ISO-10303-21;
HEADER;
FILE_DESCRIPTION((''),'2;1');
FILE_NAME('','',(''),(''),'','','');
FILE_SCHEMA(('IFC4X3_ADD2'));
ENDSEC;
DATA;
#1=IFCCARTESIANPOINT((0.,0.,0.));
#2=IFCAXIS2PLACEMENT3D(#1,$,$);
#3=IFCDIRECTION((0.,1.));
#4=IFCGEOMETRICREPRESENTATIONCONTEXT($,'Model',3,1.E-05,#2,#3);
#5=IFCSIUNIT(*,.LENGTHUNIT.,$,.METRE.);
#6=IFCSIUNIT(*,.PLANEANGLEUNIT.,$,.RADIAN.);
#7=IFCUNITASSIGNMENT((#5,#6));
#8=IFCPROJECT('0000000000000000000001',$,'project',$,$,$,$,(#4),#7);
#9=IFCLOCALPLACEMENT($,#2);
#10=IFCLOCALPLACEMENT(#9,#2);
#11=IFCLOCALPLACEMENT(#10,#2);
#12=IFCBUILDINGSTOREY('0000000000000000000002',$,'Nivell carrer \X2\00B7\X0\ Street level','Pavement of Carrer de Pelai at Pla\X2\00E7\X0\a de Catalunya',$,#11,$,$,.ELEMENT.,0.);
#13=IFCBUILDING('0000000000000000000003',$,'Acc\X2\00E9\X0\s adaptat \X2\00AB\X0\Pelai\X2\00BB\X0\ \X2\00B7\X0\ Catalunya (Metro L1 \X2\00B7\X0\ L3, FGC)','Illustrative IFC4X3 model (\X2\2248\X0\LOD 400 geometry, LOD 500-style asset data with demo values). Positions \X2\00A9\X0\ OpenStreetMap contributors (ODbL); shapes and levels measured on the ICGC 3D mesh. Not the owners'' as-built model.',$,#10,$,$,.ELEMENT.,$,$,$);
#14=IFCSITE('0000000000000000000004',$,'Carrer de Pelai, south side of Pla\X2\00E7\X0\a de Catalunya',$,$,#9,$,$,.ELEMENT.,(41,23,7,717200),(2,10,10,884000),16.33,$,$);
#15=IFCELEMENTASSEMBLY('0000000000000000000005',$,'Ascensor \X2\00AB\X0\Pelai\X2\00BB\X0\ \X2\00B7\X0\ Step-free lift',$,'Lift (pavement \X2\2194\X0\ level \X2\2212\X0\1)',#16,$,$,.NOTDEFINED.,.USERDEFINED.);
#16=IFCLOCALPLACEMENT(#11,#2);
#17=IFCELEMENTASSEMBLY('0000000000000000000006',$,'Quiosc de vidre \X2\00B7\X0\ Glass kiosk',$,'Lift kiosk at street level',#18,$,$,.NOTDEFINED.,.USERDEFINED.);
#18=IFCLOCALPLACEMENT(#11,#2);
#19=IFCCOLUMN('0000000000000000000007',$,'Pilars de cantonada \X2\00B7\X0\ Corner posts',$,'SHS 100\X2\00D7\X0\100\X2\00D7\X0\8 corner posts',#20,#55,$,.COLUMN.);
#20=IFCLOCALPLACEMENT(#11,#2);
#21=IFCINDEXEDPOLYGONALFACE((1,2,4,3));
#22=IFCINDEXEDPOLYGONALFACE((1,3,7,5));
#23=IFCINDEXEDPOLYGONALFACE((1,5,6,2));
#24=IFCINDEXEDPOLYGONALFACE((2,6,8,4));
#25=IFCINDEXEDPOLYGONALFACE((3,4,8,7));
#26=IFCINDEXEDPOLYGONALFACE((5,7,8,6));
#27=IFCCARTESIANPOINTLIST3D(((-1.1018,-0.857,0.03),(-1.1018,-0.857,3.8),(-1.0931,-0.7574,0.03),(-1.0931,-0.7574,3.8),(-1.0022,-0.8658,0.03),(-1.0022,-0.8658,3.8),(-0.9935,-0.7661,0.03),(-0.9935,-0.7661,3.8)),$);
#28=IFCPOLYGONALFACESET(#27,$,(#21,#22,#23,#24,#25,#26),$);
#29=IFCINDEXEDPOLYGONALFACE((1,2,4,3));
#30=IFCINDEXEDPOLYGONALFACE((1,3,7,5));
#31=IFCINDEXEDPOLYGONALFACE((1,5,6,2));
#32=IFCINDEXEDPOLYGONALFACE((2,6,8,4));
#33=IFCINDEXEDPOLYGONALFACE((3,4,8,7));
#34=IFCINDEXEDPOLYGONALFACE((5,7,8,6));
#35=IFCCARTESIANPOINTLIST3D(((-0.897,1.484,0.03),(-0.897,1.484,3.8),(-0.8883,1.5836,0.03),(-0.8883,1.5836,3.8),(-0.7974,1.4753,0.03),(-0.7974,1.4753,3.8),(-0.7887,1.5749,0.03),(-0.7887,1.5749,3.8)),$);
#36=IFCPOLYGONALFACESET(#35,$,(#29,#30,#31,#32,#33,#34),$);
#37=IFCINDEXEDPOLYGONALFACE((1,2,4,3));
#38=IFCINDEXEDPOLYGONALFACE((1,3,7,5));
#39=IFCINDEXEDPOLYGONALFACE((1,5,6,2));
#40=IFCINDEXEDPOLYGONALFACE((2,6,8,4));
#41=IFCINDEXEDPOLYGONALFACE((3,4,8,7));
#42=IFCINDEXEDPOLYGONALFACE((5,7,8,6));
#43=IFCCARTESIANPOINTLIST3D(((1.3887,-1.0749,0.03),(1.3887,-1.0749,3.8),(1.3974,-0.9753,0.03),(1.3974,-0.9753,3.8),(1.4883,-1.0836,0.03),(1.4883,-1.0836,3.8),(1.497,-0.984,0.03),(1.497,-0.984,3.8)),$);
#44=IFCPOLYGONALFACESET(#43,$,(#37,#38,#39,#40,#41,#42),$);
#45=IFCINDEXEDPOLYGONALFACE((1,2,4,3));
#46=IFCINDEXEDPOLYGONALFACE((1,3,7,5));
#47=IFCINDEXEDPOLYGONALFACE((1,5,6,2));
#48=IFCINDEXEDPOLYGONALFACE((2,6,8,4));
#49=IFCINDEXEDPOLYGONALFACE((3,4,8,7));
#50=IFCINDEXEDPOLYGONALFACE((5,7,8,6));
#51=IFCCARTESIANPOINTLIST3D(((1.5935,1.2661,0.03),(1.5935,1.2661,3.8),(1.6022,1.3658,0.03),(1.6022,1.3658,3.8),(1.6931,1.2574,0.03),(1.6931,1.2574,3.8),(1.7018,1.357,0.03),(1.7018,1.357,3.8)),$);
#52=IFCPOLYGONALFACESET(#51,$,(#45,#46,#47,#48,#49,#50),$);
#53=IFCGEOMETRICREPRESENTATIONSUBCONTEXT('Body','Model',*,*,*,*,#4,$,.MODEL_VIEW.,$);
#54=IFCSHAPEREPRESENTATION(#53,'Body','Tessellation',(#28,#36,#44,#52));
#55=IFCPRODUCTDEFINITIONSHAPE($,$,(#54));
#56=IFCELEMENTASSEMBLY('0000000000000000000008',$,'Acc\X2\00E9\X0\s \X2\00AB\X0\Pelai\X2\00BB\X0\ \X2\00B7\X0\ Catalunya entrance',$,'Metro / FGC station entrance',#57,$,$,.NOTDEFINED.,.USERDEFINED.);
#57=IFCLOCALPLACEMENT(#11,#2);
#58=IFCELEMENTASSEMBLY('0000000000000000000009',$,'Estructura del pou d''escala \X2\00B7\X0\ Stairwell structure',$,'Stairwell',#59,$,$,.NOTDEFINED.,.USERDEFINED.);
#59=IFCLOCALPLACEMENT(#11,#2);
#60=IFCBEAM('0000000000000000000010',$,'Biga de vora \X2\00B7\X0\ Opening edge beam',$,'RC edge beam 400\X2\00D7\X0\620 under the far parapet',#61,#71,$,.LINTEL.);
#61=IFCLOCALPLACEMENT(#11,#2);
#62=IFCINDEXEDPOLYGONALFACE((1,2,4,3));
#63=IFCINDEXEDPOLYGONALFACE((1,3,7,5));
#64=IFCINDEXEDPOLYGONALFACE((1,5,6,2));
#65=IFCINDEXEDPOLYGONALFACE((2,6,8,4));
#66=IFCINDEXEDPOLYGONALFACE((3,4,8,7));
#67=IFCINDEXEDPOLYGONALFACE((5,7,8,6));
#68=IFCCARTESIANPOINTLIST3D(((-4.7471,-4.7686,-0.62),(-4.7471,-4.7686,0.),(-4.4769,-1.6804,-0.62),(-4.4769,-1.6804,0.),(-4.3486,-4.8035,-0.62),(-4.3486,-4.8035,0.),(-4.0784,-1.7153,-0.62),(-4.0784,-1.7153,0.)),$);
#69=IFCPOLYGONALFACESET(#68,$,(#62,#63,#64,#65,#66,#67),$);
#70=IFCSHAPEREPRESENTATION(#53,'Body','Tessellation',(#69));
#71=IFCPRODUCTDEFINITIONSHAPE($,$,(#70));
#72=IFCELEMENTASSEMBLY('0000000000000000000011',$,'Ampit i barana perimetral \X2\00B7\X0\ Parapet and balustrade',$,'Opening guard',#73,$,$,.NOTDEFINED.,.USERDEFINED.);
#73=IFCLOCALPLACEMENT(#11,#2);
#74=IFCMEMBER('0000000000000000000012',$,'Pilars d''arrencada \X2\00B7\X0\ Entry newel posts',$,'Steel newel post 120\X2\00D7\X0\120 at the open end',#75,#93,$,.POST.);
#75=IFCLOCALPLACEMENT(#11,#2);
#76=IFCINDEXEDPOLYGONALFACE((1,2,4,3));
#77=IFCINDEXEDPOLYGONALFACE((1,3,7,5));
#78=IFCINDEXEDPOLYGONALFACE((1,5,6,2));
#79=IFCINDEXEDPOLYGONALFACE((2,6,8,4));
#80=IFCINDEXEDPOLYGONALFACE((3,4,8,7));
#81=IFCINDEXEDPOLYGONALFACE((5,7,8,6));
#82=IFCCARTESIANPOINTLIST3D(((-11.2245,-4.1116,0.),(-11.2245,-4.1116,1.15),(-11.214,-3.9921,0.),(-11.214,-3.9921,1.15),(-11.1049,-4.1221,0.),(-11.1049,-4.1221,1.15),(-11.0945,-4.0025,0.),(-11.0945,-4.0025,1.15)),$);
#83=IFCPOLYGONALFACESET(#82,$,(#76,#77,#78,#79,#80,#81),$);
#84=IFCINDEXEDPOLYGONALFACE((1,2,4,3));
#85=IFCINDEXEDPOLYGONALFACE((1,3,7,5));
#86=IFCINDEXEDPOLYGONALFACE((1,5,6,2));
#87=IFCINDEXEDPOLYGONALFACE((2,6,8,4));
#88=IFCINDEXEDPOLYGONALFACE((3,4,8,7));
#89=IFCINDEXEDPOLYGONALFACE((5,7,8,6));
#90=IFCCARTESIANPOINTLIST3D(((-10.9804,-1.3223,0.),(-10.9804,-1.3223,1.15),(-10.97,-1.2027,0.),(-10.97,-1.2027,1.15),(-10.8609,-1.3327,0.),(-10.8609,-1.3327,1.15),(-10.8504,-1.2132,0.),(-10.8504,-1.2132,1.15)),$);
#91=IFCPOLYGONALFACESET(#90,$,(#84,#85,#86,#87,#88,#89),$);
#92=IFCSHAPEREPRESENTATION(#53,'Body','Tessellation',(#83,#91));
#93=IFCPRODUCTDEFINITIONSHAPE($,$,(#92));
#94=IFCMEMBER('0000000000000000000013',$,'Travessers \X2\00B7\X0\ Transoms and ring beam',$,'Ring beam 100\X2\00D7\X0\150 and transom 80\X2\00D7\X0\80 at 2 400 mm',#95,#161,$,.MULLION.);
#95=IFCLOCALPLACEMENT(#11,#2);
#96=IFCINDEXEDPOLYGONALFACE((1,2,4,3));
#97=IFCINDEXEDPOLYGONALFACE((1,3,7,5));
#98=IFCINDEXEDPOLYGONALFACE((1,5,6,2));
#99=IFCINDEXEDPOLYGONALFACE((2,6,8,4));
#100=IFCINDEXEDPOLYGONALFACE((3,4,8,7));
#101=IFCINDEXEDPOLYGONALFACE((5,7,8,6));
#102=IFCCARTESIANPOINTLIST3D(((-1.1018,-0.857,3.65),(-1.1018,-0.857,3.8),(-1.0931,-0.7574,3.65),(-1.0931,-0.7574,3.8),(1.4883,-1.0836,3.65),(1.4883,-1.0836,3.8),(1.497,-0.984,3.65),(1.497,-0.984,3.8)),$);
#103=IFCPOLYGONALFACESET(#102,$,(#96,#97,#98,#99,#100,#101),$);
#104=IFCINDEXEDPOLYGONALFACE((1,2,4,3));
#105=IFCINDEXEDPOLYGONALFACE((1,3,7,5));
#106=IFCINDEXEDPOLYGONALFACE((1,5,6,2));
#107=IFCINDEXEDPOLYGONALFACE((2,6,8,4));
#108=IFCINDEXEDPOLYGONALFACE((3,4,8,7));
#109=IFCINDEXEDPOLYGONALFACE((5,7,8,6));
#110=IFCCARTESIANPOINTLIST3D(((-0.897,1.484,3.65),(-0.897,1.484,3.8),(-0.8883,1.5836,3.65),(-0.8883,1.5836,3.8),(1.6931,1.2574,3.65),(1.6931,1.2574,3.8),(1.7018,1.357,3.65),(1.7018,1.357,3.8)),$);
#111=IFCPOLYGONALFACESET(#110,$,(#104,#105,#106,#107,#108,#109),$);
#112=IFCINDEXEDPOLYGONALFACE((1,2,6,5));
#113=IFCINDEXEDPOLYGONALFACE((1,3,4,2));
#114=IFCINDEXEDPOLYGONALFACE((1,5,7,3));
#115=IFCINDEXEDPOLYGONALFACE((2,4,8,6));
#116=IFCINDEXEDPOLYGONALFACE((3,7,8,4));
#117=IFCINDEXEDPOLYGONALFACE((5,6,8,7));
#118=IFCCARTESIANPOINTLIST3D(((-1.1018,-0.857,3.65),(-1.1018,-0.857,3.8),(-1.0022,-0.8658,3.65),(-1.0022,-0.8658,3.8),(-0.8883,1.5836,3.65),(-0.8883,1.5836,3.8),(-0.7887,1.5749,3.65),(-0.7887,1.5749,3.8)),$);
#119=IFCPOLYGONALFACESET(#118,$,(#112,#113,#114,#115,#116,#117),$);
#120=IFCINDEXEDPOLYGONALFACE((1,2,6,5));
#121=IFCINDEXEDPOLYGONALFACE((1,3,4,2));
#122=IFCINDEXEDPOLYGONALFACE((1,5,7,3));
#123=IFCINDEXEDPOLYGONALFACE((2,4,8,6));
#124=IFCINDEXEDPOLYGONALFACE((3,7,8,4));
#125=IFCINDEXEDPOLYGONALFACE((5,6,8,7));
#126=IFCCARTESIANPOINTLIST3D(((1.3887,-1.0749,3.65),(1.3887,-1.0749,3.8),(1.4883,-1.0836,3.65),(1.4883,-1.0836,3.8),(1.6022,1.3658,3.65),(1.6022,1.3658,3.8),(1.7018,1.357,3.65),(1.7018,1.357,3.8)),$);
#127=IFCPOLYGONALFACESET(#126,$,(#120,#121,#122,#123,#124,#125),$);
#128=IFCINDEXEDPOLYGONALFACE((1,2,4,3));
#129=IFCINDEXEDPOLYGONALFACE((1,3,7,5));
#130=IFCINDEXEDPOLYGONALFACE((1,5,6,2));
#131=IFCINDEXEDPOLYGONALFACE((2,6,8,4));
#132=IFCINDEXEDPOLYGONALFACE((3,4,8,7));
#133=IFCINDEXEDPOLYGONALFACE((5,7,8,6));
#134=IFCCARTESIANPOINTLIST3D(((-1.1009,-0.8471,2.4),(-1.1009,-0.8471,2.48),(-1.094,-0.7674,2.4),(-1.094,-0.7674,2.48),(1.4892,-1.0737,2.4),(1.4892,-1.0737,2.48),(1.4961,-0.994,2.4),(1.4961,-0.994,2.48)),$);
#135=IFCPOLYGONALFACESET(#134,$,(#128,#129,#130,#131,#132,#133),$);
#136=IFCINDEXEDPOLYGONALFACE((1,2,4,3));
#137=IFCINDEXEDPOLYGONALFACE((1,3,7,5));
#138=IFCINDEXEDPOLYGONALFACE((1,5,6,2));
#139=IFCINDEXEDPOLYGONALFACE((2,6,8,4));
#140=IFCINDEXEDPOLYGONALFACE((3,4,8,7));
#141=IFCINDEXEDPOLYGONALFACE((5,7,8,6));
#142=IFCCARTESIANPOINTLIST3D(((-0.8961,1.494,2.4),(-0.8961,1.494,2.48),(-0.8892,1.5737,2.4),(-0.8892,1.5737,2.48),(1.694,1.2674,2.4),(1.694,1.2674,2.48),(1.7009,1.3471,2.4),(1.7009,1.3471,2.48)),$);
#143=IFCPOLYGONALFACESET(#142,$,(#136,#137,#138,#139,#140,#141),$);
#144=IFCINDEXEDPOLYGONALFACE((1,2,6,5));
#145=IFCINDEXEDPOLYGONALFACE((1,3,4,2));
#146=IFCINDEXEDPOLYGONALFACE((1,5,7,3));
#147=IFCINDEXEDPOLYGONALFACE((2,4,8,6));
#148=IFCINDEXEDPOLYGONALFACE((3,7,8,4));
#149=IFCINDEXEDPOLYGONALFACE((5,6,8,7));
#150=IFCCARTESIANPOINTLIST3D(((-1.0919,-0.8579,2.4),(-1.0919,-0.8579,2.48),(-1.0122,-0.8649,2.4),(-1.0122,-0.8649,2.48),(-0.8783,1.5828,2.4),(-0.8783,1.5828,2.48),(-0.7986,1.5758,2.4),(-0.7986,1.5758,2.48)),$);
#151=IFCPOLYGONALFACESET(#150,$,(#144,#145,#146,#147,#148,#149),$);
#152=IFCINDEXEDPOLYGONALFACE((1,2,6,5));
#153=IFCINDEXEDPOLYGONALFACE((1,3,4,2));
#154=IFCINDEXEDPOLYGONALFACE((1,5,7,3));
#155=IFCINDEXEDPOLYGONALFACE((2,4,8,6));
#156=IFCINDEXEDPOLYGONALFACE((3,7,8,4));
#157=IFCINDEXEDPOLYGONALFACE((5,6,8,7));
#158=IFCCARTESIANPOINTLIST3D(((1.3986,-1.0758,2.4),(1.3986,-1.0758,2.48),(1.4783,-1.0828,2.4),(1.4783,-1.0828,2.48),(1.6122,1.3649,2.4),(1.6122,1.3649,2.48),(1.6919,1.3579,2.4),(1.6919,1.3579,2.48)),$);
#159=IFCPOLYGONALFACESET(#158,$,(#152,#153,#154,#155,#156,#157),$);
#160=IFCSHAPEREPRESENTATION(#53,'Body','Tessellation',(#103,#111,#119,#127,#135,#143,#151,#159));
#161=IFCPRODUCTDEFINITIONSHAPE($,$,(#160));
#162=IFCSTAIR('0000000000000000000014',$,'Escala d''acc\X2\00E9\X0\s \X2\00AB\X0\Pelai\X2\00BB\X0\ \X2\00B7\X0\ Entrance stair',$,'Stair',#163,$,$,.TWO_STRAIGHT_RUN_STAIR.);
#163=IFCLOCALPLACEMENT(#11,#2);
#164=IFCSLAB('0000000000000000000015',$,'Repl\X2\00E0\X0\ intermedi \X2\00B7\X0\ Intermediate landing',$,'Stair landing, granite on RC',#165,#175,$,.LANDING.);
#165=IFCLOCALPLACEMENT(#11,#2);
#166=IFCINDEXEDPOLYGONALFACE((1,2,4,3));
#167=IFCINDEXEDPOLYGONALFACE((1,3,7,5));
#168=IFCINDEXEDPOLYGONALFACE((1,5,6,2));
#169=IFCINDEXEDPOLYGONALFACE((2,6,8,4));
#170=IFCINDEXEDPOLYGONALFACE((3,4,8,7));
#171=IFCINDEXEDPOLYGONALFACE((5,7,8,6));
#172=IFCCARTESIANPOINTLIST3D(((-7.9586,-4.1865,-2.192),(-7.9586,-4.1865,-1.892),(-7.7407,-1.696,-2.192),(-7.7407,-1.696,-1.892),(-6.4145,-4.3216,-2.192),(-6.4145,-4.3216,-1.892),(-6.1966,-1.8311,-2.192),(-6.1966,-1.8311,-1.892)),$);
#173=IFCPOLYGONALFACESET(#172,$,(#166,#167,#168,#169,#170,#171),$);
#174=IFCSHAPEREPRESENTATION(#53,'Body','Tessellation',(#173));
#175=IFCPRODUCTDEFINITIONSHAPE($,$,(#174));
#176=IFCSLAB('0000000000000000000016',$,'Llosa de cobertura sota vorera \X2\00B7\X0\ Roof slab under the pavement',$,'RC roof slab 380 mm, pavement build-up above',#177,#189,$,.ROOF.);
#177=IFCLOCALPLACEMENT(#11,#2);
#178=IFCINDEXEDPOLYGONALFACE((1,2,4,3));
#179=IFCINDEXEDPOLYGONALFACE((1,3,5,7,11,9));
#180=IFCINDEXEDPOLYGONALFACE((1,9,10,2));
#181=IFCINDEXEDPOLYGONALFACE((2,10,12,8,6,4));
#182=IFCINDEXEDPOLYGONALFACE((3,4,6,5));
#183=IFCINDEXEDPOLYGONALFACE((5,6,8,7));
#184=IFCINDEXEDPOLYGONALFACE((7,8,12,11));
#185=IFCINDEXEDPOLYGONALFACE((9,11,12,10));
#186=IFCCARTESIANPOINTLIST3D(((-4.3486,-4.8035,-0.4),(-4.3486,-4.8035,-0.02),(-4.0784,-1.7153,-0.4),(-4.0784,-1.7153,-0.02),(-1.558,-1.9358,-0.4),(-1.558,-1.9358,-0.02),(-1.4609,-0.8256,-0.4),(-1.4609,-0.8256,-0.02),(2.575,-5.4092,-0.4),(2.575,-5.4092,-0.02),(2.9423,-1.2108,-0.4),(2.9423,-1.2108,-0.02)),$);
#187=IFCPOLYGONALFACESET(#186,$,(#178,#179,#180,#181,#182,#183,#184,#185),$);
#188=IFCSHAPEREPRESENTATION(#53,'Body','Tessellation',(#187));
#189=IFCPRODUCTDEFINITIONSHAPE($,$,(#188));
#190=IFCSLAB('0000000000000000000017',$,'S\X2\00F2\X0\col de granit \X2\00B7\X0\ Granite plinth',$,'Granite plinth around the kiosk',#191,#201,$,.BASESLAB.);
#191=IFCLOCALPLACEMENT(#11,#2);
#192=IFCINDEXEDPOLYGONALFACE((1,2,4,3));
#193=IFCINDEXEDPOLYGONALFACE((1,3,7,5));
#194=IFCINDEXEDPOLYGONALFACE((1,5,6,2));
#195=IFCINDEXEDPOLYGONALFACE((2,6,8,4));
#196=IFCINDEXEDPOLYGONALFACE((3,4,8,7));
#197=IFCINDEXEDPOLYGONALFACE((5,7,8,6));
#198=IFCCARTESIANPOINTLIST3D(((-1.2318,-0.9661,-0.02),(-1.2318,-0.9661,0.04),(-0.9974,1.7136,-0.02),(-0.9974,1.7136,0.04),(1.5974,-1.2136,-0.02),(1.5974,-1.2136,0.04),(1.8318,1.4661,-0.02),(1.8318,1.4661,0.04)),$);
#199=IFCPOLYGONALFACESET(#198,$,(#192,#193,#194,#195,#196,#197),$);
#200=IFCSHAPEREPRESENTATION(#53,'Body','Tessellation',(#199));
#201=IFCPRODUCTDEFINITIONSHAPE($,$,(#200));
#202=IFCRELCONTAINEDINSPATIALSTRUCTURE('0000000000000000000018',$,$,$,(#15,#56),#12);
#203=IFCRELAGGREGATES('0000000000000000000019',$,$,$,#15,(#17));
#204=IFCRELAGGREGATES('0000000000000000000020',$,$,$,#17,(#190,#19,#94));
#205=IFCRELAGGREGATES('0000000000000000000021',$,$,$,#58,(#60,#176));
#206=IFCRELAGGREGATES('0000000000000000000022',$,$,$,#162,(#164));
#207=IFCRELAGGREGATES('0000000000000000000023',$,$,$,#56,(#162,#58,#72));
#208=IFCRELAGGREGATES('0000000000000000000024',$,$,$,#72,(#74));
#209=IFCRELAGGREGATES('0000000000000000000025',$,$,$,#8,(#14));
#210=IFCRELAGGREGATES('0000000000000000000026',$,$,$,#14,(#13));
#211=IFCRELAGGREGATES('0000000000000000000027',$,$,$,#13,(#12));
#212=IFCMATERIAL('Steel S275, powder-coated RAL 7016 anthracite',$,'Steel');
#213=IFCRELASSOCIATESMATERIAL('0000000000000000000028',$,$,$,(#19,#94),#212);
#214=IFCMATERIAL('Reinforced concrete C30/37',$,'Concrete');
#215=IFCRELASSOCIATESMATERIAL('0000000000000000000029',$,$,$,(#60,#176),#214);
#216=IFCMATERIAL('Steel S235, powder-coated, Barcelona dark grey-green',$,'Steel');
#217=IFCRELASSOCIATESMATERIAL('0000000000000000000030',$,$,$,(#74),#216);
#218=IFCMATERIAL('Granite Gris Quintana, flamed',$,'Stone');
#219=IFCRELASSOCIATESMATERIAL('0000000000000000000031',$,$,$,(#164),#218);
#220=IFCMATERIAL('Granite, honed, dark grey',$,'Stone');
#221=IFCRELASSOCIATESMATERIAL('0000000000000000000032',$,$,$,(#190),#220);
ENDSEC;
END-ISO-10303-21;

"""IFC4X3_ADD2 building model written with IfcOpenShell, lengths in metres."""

from ifc_helpers import new_model, si_unit, direction, frame, frame_2d, origin, place, context, subcontext, project, spatial, polyline, rectangle, outline, extrude, material, element, aggregate, save


model = new_model("IFC4X3_ADD2")

# Units and contexts
model_context = context("Model", 3, precision=1e-05, world=origin(), true_north=direction((0.0, 1.0)))
body_context = subcontext(model_context, "Body", "Model", "MODEL_VIEW")
ifc_project = project(units=[si_unit("LENGTHUNIT", "METRE"), si_unit("PLANEANGLEUNIT", "RADIAN")], contexts=[model_context])

# Site, building, storey
site_placement = place(None, origin())
site = spatial("IfcSite", under=ifc_project, at=site_placement, Name="Carrer de Pelai, south side of Plaça de Catalunya", CompositionType="ELEMENT", RefLatitude=(41, 23, 7, 717200), RefLongitude=(2, 10, 10, 884000), RefElevation=16.33)
building_placement = place(site_placement, origin())
building = spatial("IfcBuilding", under=site, at=building_placement, Name="Accés adaptat «Pelai» · Catalunya (Metro L1 · L3, FGC)", Description="Illustrative IFC4X3 model (≈LOD 400 geometry, LOD 500-style asset data with demo values). Positions © OpenStreetMap contributors (ODbL); shapes and levels measured on the ICGC 3D mesh. Not the owners' as-built model.", CompositionType="ELEMENT")
storey_placement = place(building_placement, origin())
storey = spatial("IfcBuildingStorey", under=building, at=storey_placement, Name="Nivell carrer · Street level", Description="Pavement of Carrer de Pelai at Plaça de Catalunya", CompositionType="ELEMENT", Elevation=0.0)

# Element assemblies, column
assembly_1_placement = place(building_placement, origin())
assembly_1 = element("IfcElementAssembly", 1, at=assembly_1_placement, inside=storey, Name="Ascensor «Pelai» · Step-free lift", ObjectType="Lift (pavement ↔ level −1)", AssemblyPlace="NOTDEFINED", PredefinedType="USERDEFINED")
assembly_2_placement = place(building_placement, origin())
assembly_2 = element("IfcElementAssembly", 2, at=assembly_2_placement, Name="Quiosc de vidre · Glass kiosk", ObjectType="Lift kiosk at street level", AssemblyPlace="NOTDEFINED", PredefinedType="USERDEFINED")
aggregate(assembly_1, [assembly_2])
ifc_material_1 = material(Name="Steel S275, powder-coated RAL 7016 anthracite", Category="Steel")
column_placement = place(building_placement, origin())
column = element("IfcColumn", 3, at=column_placement, material=ifc_material_1, Name="Pilars de cantonada · Corner posts", ObjectType="SHS 100×100×8 corner posts", PredefinedType="COLUMN", context=body_context, shape_type="SweptSolid", body=[
    extrude(rectangle(XDim=0.1, YDim=0.1, at=frame_2d((0.0, 0.0), x_axis=(0.996195, -0.087156))), frame((-1.0477, -0.8116, 0.03)), (0.0, 0.0, 1.0), 3.77),
    extrude(rectangle(XDim=0.1, YDim=0.1, at=frame_2d((0.0, 0.0), x_axis=(0.996195, -0.087156))), frame((-0.8428, 1.5295, 0.03)), (0.0, 0.0, 1.0), 3.77),
    extrude(rectangle(XDim=0.1, YDim=0.1, at=frame_2d((0.0, 0.0), x_axis=(0.996195, -0.087156))), frame((1.4428, -1.0295, 0.03)), (0.0, 0.0, 1.0), 3.77),
    extrude(rectangle(XDim=0.1, YDim=0.1, at=frame_2d((0.0, 0.0), x_axis=(0.996195, -0.087156))), frame((1.6477, 1.3116, 0.03)), (0.0, 0.0, 1.0), 3.77),
])

# Element assemblies, beam, member
assembly_3_placement = place(building_placement, origin())
assembly_3 = element("IfcElementAssembly", 4, at=assembly_3_placement, inside=storey, Name="Accés «Pelai» · Catalunya entrance", ObjectType="Metro / FGC station entrance", AssemblyPlace="NOTDEFINED", PredefinedType="USERDEFINED")
assembly_4_placement = place(building_placement, origin())
assembly_4 = element("IfcElementAssembly", 5, at=assembly_4_placement, Name="Estructura del pou d'escala · Stairwell structure", ObjectType="Stairwell", AssemblyPlace="NOTDEFINED", PredefinedType="USERDEFINED")
ifc_material_2 = material(Name="Reinforced concrete C30/37", Category="Concrete")
beam_placement = place(building_placement, origin())
beam = element("IfcBeam", 6, at=beam_placement, material=ifc_material_2, Name="Biga de vora · Opening edge beam", ObjectType="RC edge beam 400×620 under the far parapet", PredefinedType="LINTEL", context=body_context, shape_type="SweptSolid", body=[
    extrude(rectangle(XDim=0.4, YDim=3.1, at=frame_2d((0.0, 0.0), x_axis=(0.996195, -0.087156))), frame((-4.4127, -3.242, -0.62)), (0.0, 0.0, 1.0), 0.62),
])
assembly_5_placement = place(building_placement, origin())
assembly_5 = element("IfcElementAssembly", 7, at=assembly_5_placement, Name="Ampit i barana perimetral · Parapet and balustrade", ObjectType="Opening guard", AssemblyPlace="NOTDEFINED", PredefinedType="USERDEFINED")
ifc_material_3 = material(Name="Steel S235, powder-coated, Barcelona dark grey-green", Category="Steel")
member_1_placement = place(building_placement, origin())
member_1 = element("IfcMember", 8, at=member_1_placement, material=ifc_material_3, Name="Pilars d'arrencada · Entry newel posts", ObjectType="Steel newel post 120×120 at the open end", PredefinedType="POST", context=body_context, shape_type="SweptSolid", body=[
    extrude(rectangle(XDim=0.12, YDim=0.12, at=frame_2d((0.0, 0.0), x_axis=(0.996195, -0.087156))), frame((-11.1595, -4.0571, 0.0)), (0.0, 0.0, 1.0), 1.15),
    extrude(rectangle(XDim=0.12, YDim=0.12, at=frame_2d((0.0, 0.0), x_axis=(0.996195, -0.087156))), frame((-10.9154, -1.2677, 0.0)), (0.0, 0.0, 1.0), 1.15),
])

# Member
member_2_placement = place(building_placement, origin())
member_2 = element("IfcMember", 9, at=member_2_placement, material=ifc_material_1, Name="Travessers · Transoms and ring beam", ObjectType="Ring beam 100×150 and transom 80×80 at 2 400 mm", PredefinedType="MULLION", context=body_context, shape_type="SweptSolid", body=[
    extrude(rectangle(XDim=2.6, YDim=0.1, at=frame_2d((0.0, 0.0), x_axis=(0.996195, -0.087156))), frame((0.1976, -0.9205, 3.65)), (0.0, 0.0, 1.0), 0.15),
    extrude(rectangle(XDim=2.6, YDim=0.1, at=frame_2d((0.0, 0.0), x_axis=(0.996195, -0.087156))), frame((0.4024, 1.4205, 3.65)), (0.0, 0.0, 1.0), 0.15),
    extrude(rectangle(XDim=0.1, YDim=2.45, at=frame_2d((0.0, 0.0), x_axis=(0.996195, -0.087156))), frame((-0.9452, 0.3589, 3.65)), (0.0, 0.0, 1.0), 0.15),
    extrude(rectangle(XDim=0.1, YDim=2.45, at=frame_2d((0.0, 0.0), x_axis=(0.996195, -0.087156))), frame((1.5452, 0.1411, 3.65)), (0.0, 0.0, 1.0), 0.15),
    extrude(rectangle(XDim=2.6, YDim=0.08, at=frame_2d((0.0, 0.0), x_axis=(0.996195, -0.087156))), frame((0.1976, -0.9205, 2.4)), (0.0, 0.0, 1.0), 0.08),
    extrude(rectangle(XDim=2.6, YDim=0.08, at=frame_2d((0.0, 0.0), x_axis=(0.996195, -0.087156))), frame((0.4024, 1.4205, 2.4)), (0.0, 0.0, 1.0), 0.08),
    extrude(rectangle(XDim=0.08, YDim=2.45, at=frame_2d((0.0, 0.0), x_axis=(0.996195, -0.087156))), frame((-0.9452, 0.3589, 2.4)), (0.0, 0.0, 1.0), 0.08),
    extrude(rectangle(XDim=0.08, YDim=2.45, at=frame_2d((0.0, 0.0), x_axis=(0.996195, -0.087156))), frame((1.5452, 0.1411, 2.4)), (0.0, 0.0, 1.0), 0.08),
])

# Stair, slab
stair_placement = place(building_placement, origin())
stair = element("IfcStair", 10, at=stair_placement, Name="Escala d'accés «Pelai» · Entrance stair", ObjectType="Stair", PredefinedType="TWO_STRAIGHT_RUN_STAIR")
ifc_material_4 = material(Name="Granite Gris Quintana, flamed", Category="Stone")
slab_1_placement = place(building_placement, origin())
slab_1 = element("IfcSlab", 11, at=slab_1_placement, material=ifc_material_4, Name="Replà intermedi · Intermediate landing", ObjectType="Stair landing, granite on RC", PredefinedType="LANDING", context=body_context, shape_type="SweptSolid", body=[
    extrude(rectangle(XDim=1.55, YDim=2.5, at=frame_2d((0.0, 0.0), x_axis=(0.996195, -0.087156))), frame((-7.0776, -3.0088, -2.192)), (0.0, 0.0, 1.0), 0.3),
])

# Slabs
slab_2_placement = place(building_placement, origin())
slab_2 = element("IfcSlab", 12, at=slab_2_placement, material=ifc_material_2, Name="Llosa de cobertura sota vorera · Roof slab under the pavement", ObjectType="RC roof slab 380 mm, pavement build-up above", PredefinedType="ROOF", context=body_context, shape_type="SweptSolid", body=[
    extrude(outline(polyline([(-4.3486, -4.8035), (2.575, -5.4092), (2.9423, -1.2108), (-1.4609, -0.8256), (-1.558, -1.9358), (-4.0784, -1.7153), (-4.3486, -4.8035)])), frame((0.0, 0.0, -0.4)), (0.0, 0.0, 1.0), 0.38),
])
ifc_material_5 = material(Name="Granite, honed, dark grey", Category="Stone")
slab_3_placement = place(building_placement, origin())
slab_3 = element("IfcSlab", 13, at=slab_3_placement, material=ifc_material_5, Name="Sòcol de granit · Granite plinth", ObjectType="Granite plinth around the kiosk", PredefinedType="BASESLAB", context=body_context, shape_type="SweptSolid", body=[
    extrude(rectangle(XDim=2.84, YDim=2.69, at=frame_2d((0.0, 0.0), x_axis=(0.996195, -0.087156))), frame((0.3, 0.25, -0.02)), (0.0, 0.0, 1.0), 0.06),
])

aggregate(assembly_2, [slab_3, column, member_2])

aggregate(assembly_4, [beam, slab_2])

aggregate(stair, [slab_1])

aggregate(assembly_3, [stair, assembly_4, assembly_5])

aggregate(assembly_5, [member_1])

save(model, "model.ifc")
